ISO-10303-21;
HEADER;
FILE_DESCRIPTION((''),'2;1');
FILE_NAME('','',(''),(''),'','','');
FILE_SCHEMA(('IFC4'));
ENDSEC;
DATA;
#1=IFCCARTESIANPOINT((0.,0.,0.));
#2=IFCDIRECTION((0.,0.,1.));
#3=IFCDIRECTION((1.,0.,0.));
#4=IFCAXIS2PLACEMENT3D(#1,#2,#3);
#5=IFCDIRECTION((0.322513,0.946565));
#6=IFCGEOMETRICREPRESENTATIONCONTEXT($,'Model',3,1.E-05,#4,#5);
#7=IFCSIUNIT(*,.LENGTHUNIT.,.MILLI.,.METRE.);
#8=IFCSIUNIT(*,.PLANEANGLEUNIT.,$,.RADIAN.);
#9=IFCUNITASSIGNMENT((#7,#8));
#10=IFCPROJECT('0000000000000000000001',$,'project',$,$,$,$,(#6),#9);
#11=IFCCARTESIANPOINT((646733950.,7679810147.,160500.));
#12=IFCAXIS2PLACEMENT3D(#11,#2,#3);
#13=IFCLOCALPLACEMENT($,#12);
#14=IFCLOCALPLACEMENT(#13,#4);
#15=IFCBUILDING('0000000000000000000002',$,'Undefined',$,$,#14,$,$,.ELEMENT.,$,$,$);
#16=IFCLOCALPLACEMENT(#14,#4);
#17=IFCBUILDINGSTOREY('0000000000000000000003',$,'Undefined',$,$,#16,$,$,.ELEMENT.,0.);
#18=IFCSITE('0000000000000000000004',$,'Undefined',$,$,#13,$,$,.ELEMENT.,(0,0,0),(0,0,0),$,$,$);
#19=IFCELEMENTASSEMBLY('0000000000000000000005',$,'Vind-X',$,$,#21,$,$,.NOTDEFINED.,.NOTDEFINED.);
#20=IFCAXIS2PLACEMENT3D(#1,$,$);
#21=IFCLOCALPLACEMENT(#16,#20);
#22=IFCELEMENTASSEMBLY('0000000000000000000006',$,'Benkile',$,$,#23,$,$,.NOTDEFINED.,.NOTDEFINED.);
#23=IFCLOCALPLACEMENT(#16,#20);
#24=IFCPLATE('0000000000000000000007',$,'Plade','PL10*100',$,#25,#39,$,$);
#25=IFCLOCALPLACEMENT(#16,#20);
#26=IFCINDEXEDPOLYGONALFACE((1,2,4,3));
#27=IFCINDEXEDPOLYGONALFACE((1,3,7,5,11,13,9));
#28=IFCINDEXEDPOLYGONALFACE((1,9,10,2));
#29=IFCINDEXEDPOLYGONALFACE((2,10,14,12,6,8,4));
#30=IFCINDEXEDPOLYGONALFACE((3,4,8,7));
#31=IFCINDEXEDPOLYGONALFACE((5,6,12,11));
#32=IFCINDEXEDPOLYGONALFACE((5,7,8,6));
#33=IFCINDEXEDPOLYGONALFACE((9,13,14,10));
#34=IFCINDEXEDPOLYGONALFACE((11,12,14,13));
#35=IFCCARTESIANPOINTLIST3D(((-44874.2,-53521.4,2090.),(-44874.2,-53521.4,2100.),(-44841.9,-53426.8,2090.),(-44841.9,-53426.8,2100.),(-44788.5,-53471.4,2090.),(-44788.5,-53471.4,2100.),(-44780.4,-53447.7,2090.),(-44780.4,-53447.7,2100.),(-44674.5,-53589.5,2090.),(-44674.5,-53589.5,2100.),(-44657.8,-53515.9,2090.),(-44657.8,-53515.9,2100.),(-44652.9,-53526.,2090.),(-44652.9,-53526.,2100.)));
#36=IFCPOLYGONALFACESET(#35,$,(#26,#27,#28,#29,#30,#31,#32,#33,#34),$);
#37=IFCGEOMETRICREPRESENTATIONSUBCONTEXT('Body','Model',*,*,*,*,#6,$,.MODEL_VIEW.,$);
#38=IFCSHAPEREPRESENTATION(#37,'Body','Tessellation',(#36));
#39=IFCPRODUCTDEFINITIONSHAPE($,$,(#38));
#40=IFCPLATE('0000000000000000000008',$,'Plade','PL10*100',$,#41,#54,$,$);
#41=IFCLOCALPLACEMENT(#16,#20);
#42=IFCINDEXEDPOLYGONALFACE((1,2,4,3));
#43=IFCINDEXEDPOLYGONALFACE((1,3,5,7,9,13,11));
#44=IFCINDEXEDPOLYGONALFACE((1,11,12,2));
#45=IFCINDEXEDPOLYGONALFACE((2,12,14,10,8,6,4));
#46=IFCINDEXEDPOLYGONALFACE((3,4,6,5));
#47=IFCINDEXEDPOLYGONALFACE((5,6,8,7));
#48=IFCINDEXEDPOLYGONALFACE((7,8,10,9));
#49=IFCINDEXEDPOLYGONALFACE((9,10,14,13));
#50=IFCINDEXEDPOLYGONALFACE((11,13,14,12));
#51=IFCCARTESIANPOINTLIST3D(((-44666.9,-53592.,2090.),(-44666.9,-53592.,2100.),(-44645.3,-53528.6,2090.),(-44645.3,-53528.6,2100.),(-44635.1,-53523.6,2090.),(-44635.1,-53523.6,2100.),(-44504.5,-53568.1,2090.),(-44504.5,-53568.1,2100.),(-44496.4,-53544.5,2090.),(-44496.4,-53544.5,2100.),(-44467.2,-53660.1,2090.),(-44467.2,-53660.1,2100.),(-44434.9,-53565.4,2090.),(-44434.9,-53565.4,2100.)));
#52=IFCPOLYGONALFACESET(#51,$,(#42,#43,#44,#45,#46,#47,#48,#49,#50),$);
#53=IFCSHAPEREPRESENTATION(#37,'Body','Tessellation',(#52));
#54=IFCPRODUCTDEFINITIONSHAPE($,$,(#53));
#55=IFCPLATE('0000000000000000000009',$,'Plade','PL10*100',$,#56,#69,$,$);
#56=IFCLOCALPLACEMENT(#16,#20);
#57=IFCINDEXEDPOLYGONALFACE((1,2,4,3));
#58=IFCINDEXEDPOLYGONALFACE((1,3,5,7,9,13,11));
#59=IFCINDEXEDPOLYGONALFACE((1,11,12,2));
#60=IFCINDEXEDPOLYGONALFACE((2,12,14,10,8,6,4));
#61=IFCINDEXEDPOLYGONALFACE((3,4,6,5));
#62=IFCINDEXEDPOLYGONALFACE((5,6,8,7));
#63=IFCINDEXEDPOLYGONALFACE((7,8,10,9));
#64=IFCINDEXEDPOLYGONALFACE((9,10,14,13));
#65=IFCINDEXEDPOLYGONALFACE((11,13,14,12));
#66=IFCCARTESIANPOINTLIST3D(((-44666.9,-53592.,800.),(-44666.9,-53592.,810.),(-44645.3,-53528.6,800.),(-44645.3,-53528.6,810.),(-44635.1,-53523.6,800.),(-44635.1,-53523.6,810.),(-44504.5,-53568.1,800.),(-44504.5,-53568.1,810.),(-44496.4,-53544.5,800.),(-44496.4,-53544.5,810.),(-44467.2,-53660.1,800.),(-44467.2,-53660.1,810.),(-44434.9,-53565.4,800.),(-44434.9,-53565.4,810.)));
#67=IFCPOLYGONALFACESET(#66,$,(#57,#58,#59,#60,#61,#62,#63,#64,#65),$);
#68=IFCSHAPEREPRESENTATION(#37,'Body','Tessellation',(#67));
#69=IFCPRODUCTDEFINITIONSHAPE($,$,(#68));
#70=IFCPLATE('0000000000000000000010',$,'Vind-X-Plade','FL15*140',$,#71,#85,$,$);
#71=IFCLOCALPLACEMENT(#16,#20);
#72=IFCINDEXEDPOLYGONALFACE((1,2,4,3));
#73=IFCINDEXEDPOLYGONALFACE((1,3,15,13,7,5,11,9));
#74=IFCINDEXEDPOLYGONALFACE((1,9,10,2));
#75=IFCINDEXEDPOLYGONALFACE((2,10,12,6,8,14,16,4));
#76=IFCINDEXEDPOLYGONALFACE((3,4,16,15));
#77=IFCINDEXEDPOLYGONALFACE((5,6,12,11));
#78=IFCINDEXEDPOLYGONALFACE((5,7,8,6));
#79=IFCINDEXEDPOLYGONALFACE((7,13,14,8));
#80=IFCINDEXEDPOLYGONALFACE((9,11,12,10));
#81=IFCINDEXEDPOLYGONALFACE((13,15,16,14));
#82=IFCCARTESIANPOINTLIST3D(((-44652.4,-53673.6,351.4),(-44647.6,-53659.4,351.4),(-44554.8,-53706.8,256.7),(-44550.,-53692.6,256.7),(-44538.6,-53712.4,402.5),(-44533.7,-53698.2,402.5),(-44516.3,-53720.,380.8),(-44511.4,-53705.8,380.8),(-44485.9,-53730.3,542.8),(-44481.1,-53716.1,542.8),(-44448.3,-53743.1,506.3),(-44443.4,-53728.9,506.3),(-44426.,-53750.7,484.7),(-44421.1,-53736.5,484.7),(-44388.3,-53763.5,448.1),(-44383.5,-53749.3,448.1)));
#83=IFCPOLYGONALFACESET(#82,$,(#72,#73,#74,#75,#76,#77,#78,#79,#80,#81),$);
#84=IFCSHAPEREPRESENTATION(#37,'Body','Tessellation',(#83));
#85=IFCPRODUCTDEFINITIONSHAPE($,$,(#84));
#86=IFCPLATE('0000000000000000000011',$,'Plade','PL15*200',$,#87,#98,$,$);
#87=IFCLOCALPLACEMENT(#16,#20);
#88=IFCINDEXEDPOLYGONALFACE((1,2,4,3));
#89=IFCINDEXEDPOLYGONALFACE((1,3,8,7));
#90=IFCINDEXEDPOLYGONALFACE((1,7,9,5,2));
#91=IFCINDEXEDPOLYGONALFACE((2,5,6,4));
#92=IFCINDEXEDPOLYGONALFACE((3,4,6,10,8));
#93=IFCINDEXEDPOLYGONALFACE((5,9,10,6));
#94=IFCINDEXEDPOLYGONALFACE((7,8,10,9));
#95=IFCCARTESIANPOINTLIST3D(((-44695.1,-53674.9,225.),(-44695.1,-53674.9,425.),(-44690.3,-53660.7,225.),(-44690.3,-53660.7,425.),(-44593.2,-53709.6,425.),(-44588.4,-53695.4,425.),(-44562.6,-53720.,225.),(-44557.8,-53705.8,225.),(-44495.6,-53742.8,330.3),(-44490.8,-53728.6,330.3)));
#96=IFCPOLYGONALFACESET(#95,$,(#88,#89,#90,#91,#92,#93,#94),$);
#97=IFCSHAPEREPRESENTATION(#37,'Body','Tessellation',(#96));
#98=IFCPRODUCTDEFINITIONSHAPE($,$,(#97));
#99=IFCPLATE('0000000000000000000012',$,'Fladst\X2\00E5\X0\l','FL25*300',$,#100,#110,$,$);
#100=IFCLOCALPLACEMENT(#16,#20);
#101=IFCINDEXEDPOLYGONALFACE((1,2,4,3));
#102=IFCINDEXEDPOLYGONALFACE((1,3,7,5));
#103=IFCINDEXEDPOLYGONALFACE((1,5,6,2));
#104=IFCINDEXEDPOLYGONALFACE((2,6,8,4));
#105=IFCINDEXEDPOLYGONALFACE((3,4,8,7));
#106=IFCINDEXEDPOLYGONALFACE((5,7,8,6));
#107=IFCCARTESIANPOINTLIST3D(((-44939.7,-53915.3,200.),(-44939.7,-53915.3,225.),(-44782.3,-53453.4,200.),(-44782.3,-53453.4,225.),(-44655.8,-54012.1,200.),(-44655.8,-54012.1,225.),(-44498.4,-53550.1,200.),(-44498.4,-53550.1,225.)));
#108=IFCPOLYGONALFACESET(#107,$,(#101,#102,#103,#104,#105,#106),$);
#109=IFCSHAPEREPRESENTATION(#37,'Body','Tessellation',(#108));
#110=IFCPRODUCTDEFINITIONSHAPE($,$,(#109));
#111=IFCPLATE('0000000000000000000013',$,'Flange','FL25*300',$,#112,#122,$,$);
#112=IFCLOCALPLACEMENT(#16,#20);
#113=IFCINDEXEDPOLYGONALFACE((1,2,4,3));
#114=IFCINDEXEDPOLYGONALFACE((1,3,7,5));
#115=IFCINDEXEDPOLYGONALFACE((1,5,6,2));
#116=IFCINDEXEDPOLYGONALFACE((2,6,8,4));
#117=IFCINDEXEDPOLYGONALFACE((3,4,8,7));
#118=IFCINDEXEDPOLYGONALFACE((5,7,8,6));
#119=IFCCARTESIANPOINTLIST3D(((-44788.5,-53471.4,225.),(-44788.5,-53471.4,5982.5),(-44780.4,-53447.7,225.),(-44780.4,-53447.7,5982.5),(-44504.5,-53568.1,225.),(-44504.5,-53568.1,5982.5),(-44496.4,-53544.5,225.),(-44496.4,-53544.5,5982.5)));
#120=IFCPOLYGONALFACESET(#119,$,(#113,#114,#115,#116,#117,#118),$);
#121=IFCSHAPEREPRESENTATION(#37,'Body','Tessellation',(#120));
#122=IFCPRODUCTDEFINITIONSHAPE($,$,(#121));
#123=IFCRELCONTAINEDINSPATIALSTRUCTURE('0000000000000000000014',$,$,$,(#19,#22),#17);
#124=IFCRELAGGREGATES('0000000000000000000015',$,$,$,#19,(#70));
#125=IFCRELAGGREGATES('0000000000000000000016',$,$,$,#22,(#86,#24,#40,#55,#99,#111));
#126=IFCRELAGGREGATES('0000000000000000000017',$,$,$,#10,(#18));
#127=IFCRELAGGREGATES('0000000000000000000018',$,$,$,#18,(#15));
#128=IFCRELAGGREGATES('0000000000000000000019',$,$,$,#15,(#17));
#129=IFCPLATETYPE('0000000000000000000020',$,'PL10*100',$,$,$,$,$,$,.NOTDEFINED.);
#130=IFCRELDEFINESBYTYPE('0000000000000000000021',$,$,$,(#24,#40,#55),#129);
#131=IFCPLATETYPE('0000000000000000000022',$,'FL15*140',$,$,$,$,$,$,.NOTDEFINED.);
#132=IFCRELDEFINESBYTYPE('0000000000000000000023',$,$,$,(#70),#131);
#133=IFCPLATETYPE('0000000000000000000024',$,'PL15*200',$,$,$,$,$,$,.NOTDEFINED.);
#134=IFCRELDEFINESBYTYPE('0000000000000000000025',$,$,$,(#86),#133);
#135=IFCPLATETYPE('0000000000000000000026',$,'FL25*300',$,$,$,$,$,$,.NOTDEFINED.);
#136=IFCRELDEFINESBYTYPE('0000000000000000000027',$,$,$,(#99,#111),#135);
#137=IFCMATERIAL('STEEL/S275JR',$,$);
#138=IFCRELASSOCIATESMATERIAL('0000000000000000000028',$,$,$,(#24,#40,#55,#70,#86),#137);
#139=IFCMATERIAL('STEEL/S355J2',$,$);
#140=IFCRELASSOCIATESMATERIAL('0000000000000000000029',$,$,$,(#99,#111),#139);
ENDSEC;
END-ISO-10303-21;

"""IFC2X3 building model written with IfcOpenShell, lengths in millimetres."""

from ifc_helpers import new_model, si_unit, direction, frame, origin_with_axes, place, context, subcontext, project, spatial, polyline, outline, extrude, boolean, clip, halfspace, material, type_object, element, aggregate, save


model = new_model("IFC2X3")

# Units and contexts
model_context = context("Model", 3, precision=1e-05, world=origin_with_axes(), true_north=direction((0.322513, 0.946565)))
body_context = subcontext(model_context, "Body", "Model", "MODEL_VIEW")
ifc_project = project(units=[si_unit("LENGTHUNIT", "METRE", prefix="MILLI"), si_unit("PLANEANGLEUNIT", "RADIAN")], contexts=[model_context])

# Site, building, storey
site_placement = place(None, frame((646733950.0, 7679810147.0, 160500.0), z_axis=(0.0, 0.0, 1.0), x_axis=(1.0, 0.0, 0.0)))
site = spatial("IfcSite", under=ifc_project, at=site_placement, Name="Undefined", CompositionType="ELEMENT", RefLatitude=(0, 0, 0), RefLongitude=(0, 0, 0))
building_placement = place(site_placement, origin_with_axes())
building = spatial("IfcBuilding", under=site, at=building_placement, Name="Undefined", CompositionType="ELEMENT")
storey_placement = place(building_placement, origin_with_axes())
storey = spatial("IfcBuildingStorey", under=building, at=storey_placement, Name="Undefined", CompositionType="ELEMENT", Elevation=0.0)

# Element assembly
assembly_1_placement = place(storey_placement, origin_with_axes())
assembly_1 = element("IfcElementAssembly", 1, at=assembly_1_placement, inside=storey, Name="Vind-X", AssemblyPlace="NOTDEFINED", PredefinedType="NOTDEFINED")
ifc_material_1 = material(Name="STEEL/S355J2")

# Element assembly
assembly_2_placement = place(storey_placement, origin_with_axes())
assembly_2 = element("IfcElementAssembly", 2, at=assembly_2_placement, inside=storey, Name="Benkile", AssemblyPlace="NOTDEFINED", PredefinedType="NOTDEFINED")

# Shared definitions
ifc_material_2 = material(Name="STEEL/S275JR")

# Plates
plate_type_1 = type_object("IfcPlateType", Name="PL10*100", PredefinedType="NOTDEFINED")
plate_1_placement = place(assembly_2_placement, frame((-44642.2, -53494.8, 2095.0), z_axis=(0.0, 0.0, 1.0), x_axis=(-0.946565, 0.322513, 0.0)))
plate_1 = element("IfcPlate", 3, at=plate_1_placement, type_object=plate_type_1, material=ifc_material_2, Name="Plade", Description="PL10*100", context=body_context, shape_type="CSG", body=[
    boolean("DIFFERENCE", extrude(outline(polyline([(0.0, 25.0), (146.0, 25.0), (146.0, 0.0), (211.0, 0.0), (211.0, 100.0), (0.0, 100.0), (0.0, 25.0)])), frame((0.0, 0.0, -5.0), z_axis=(0.0, 0.0, 1.0), x_axis=(1.0, 0.0, 0.0)), (0.0, 0.0, 1.0), 10.0), extrude(outline(polyline([(0.0, 0.0), (8.0, 0.0), (0.0, 8.0), (0.0, 0.0)])), frame((0.0, 25.0, -7.5), z_axis=(0.0, 0.0, 1.0), x_axis=(1.0, 0.0, 0.0)), (0.0, 0.0, 1.0), 15.0)),
])
plate_2_placement = place(assembly_2_placement, frame((-44666.9, -53592.0, 2095.0), z_axis=(0.0, 0.0, 1.0), x_axis=(0.946565, -0.322513, 0.0)))
plate_2 = element("IfcPlate", 4, at=plate_2_placement, type_object=plate_type_1, material=ifc_material_2, Name="Plade", Description="PL10*100", context=body_context, shape_type="CSG", body=[
    boolean("DIFFERENCE", extrude(outline(polyline([(0.0, 0.0), (211.0, 0.0), (211.0, 100.0), (146.0, 100.0), (146.0, 75.0), (0.0, 75.0), (0.0, 0.0)])), frame((0.0, 0.0, -5.0), z_axis=(0.0, 0.0, 1.0), x_axis=(1.0, 0.0, 0.0)), (0.0, 0.0, 1.0), 10.0), extrude(outline(polyline([(0.0, 0.0), (8.0, 0.0), (0.0, 8.0), (0.0, 0.0)])), frame((0.0, 75.0, 7.5), z_axis=(0.0, 0.0, -1.0), x_axis=(1.0, 0.0, 0.0)), (0.0, 0.0, 1.0), 15.0)),
])
plate_3_placement = place(assembly_2_placement, frame((-44666.9, -53592.0, 805.0), z_axis=(0.0, 0.0, 1.0), x_axis=(0.946565, -0.322513, 0.0)))
plate_3 = element("IfcPlate", 5, at=plate_3_placement, type_object=plate_type_1, material=ifc_material_2, Name="Plade", Description="PL10*100", context=body_context, shape_type="CSG", body=[
    boolean("DIFFERENCE", extrude(outline(polyline([(0.0, 0.0), (211.0, 0.0), (211.0, 100.0), (146.0, 100.0), (146.0, 75.0), (0.0, 75.0), (0.0, 0.0)])), frame((0.0, 0.0, -5.0), z_axis=(0.0, 0.0, 1.0), x_axis=(1.0, 0.0, 0.0)), (0.0, 0.0, 1.0), 10.0), extrude(outline(polyline([(0.0, 0.0), (8.0, 0.0), (0.0, 8.0), (0.0, 0.0)])), frame((0.0, 75.0, 7.5), z_axis=(0.0, 0.0, -1.0), x_axis=(1.0, 0.0, 0.0)), (0.0, 0.0, 1.0), 15.0)),
])
plate_type_2 = type_object("IfcPlateType", Name="FL15*140", PredefinedType="NOTDEFINED")
plate_4_placement = place(assembly_1_placement, frame((-44385.9, -53756.4, 448.1), z_axis=(0.322513, 0.946565, 0.0), x_axis=(-0.640354, 0.218181, -0.73644)))
plate_4 = element("IfcPlate", 6, at=plate_4_placement, type_object=plate_type_2, material=ifc_material_2, Name="Vind-X-Plade", Description="FL15*140", context=body_context, shape_type="SweptSolid", body=[
    extrude(outline(polyline([(0.0, 0.0), (260.0, 0.0), (260.0, 140.0), (0.0, 140.0), (0.0, 86.0), (141.0, 86.0), (141.0, 54.0), (0.0, 54.0), (0.0, 0.0)])), frame((0.0, 0.0, -7.5), z_axis=(0.0, 0.0, 1.0), x_axis=(1.0, 0.0, 0.0)), (0.0, 0.0, 1.0), 15.0),
])
plate_type_3 = type_object("IfcPlateType", Name="PL15*200", PredefinedType="NOTDEFINED")
plate_5_placement = place(assembly_2_placement, frame((-44692.7, -53667.8, 225.0), z_axis=(0.322513, 0.946565, 0.0), x_axis=(0.0, 0.0, 1.0)))
plate_5 = element("IfcPlate", 7, at=plate_5_placement, type_object=plate_type_3, material=ifc_material_2, Name="Plade", Description="PL15*200", context=body_context, shape_type="SweptSolid", body=[
    extrude(outline(polyline([(0.0, 0.0), (200.0, 0.0), (200.0, 107.7), (105.3, 210.8), (0.0, 140.0), (0.0, 0.0)])), frame((0.0, 0.0, -7.5), z_axis=(0.0, 0.0, 1.0), x_axis=(1.0, 0.0, 0.0)), (0.0, 0.0, 1.0), 15.0),
])
plate_type_4 = type_object("IfcPlateType", Name="FL25*300", PredefinedType="NOTDEFINED")
plate_6_placement = place(assembly_2_placement, frame((-44640.4, -53501.8, 212.5), z_axis=(0.0, 0.0, -1.0), x_axis=(-0.322513, -0.946565, 0.0)))
plate_6 = element("IfcPlate", 8, at=plate_6_placement, type_object=plate_type_4, material=ifc_material_1, Name="Fladstål", Description="FL25*300", context=body_context, shape_type="SweptSolid", body=[
    extrude(outline(polyline([(0.0, -150.0), (0.0, 150.0), (488.0, 150.0), (488.0, -150.0), (0.0, -150.0)])), frame((0.0, 0.0, -12.5), z_axis=(0.0, 0.0, 1.0), x_axis=(1.0, 0.0, 0.0)), (0.0, 0.0, 1.0), 25.0),
])
plate_7_placement = place(assembly_2_placement, frame((-44642.5, -53507.9, 200.0), z_axis=(-0.322513, -0.946565, 0.0), x_axis=(0.0, 0.0, 1.0)))
plate_7 = element("IfcPlate", 9, at=plate_7_placement, type_object=plate_type_4, material=ifc_material_1, Name="Flange", Description="FL25*300", context=body_context, shape_type="Clipping", body=[
    clip(extrude(outline(polyline([(25.0, -150.0), (25.0, 150.0), (5782.5, 150.0), (5782.5, -150.0), (25.0, -150.0)])), frame((0.0, 0.0, -12.5), z_axis=(0.0, 0.0, 1.0), x_axis=(1.0, 0.0, 0.0)), (0.0, 0.0, 1.0), 25.0), halfspace(frame((25.0, 0.0, 12.5), z_axis=(-1.0, 0.0, 0.0), x_axis=(0.0, 1.0, 0.0)), False)),
])

aggregate(assembly_1, [plate_4])
aggregate(assembly_2, [plate_5, plate_1, plate_2, plate_3, plate_6, plate_7])

save(model, "model.ifc")
